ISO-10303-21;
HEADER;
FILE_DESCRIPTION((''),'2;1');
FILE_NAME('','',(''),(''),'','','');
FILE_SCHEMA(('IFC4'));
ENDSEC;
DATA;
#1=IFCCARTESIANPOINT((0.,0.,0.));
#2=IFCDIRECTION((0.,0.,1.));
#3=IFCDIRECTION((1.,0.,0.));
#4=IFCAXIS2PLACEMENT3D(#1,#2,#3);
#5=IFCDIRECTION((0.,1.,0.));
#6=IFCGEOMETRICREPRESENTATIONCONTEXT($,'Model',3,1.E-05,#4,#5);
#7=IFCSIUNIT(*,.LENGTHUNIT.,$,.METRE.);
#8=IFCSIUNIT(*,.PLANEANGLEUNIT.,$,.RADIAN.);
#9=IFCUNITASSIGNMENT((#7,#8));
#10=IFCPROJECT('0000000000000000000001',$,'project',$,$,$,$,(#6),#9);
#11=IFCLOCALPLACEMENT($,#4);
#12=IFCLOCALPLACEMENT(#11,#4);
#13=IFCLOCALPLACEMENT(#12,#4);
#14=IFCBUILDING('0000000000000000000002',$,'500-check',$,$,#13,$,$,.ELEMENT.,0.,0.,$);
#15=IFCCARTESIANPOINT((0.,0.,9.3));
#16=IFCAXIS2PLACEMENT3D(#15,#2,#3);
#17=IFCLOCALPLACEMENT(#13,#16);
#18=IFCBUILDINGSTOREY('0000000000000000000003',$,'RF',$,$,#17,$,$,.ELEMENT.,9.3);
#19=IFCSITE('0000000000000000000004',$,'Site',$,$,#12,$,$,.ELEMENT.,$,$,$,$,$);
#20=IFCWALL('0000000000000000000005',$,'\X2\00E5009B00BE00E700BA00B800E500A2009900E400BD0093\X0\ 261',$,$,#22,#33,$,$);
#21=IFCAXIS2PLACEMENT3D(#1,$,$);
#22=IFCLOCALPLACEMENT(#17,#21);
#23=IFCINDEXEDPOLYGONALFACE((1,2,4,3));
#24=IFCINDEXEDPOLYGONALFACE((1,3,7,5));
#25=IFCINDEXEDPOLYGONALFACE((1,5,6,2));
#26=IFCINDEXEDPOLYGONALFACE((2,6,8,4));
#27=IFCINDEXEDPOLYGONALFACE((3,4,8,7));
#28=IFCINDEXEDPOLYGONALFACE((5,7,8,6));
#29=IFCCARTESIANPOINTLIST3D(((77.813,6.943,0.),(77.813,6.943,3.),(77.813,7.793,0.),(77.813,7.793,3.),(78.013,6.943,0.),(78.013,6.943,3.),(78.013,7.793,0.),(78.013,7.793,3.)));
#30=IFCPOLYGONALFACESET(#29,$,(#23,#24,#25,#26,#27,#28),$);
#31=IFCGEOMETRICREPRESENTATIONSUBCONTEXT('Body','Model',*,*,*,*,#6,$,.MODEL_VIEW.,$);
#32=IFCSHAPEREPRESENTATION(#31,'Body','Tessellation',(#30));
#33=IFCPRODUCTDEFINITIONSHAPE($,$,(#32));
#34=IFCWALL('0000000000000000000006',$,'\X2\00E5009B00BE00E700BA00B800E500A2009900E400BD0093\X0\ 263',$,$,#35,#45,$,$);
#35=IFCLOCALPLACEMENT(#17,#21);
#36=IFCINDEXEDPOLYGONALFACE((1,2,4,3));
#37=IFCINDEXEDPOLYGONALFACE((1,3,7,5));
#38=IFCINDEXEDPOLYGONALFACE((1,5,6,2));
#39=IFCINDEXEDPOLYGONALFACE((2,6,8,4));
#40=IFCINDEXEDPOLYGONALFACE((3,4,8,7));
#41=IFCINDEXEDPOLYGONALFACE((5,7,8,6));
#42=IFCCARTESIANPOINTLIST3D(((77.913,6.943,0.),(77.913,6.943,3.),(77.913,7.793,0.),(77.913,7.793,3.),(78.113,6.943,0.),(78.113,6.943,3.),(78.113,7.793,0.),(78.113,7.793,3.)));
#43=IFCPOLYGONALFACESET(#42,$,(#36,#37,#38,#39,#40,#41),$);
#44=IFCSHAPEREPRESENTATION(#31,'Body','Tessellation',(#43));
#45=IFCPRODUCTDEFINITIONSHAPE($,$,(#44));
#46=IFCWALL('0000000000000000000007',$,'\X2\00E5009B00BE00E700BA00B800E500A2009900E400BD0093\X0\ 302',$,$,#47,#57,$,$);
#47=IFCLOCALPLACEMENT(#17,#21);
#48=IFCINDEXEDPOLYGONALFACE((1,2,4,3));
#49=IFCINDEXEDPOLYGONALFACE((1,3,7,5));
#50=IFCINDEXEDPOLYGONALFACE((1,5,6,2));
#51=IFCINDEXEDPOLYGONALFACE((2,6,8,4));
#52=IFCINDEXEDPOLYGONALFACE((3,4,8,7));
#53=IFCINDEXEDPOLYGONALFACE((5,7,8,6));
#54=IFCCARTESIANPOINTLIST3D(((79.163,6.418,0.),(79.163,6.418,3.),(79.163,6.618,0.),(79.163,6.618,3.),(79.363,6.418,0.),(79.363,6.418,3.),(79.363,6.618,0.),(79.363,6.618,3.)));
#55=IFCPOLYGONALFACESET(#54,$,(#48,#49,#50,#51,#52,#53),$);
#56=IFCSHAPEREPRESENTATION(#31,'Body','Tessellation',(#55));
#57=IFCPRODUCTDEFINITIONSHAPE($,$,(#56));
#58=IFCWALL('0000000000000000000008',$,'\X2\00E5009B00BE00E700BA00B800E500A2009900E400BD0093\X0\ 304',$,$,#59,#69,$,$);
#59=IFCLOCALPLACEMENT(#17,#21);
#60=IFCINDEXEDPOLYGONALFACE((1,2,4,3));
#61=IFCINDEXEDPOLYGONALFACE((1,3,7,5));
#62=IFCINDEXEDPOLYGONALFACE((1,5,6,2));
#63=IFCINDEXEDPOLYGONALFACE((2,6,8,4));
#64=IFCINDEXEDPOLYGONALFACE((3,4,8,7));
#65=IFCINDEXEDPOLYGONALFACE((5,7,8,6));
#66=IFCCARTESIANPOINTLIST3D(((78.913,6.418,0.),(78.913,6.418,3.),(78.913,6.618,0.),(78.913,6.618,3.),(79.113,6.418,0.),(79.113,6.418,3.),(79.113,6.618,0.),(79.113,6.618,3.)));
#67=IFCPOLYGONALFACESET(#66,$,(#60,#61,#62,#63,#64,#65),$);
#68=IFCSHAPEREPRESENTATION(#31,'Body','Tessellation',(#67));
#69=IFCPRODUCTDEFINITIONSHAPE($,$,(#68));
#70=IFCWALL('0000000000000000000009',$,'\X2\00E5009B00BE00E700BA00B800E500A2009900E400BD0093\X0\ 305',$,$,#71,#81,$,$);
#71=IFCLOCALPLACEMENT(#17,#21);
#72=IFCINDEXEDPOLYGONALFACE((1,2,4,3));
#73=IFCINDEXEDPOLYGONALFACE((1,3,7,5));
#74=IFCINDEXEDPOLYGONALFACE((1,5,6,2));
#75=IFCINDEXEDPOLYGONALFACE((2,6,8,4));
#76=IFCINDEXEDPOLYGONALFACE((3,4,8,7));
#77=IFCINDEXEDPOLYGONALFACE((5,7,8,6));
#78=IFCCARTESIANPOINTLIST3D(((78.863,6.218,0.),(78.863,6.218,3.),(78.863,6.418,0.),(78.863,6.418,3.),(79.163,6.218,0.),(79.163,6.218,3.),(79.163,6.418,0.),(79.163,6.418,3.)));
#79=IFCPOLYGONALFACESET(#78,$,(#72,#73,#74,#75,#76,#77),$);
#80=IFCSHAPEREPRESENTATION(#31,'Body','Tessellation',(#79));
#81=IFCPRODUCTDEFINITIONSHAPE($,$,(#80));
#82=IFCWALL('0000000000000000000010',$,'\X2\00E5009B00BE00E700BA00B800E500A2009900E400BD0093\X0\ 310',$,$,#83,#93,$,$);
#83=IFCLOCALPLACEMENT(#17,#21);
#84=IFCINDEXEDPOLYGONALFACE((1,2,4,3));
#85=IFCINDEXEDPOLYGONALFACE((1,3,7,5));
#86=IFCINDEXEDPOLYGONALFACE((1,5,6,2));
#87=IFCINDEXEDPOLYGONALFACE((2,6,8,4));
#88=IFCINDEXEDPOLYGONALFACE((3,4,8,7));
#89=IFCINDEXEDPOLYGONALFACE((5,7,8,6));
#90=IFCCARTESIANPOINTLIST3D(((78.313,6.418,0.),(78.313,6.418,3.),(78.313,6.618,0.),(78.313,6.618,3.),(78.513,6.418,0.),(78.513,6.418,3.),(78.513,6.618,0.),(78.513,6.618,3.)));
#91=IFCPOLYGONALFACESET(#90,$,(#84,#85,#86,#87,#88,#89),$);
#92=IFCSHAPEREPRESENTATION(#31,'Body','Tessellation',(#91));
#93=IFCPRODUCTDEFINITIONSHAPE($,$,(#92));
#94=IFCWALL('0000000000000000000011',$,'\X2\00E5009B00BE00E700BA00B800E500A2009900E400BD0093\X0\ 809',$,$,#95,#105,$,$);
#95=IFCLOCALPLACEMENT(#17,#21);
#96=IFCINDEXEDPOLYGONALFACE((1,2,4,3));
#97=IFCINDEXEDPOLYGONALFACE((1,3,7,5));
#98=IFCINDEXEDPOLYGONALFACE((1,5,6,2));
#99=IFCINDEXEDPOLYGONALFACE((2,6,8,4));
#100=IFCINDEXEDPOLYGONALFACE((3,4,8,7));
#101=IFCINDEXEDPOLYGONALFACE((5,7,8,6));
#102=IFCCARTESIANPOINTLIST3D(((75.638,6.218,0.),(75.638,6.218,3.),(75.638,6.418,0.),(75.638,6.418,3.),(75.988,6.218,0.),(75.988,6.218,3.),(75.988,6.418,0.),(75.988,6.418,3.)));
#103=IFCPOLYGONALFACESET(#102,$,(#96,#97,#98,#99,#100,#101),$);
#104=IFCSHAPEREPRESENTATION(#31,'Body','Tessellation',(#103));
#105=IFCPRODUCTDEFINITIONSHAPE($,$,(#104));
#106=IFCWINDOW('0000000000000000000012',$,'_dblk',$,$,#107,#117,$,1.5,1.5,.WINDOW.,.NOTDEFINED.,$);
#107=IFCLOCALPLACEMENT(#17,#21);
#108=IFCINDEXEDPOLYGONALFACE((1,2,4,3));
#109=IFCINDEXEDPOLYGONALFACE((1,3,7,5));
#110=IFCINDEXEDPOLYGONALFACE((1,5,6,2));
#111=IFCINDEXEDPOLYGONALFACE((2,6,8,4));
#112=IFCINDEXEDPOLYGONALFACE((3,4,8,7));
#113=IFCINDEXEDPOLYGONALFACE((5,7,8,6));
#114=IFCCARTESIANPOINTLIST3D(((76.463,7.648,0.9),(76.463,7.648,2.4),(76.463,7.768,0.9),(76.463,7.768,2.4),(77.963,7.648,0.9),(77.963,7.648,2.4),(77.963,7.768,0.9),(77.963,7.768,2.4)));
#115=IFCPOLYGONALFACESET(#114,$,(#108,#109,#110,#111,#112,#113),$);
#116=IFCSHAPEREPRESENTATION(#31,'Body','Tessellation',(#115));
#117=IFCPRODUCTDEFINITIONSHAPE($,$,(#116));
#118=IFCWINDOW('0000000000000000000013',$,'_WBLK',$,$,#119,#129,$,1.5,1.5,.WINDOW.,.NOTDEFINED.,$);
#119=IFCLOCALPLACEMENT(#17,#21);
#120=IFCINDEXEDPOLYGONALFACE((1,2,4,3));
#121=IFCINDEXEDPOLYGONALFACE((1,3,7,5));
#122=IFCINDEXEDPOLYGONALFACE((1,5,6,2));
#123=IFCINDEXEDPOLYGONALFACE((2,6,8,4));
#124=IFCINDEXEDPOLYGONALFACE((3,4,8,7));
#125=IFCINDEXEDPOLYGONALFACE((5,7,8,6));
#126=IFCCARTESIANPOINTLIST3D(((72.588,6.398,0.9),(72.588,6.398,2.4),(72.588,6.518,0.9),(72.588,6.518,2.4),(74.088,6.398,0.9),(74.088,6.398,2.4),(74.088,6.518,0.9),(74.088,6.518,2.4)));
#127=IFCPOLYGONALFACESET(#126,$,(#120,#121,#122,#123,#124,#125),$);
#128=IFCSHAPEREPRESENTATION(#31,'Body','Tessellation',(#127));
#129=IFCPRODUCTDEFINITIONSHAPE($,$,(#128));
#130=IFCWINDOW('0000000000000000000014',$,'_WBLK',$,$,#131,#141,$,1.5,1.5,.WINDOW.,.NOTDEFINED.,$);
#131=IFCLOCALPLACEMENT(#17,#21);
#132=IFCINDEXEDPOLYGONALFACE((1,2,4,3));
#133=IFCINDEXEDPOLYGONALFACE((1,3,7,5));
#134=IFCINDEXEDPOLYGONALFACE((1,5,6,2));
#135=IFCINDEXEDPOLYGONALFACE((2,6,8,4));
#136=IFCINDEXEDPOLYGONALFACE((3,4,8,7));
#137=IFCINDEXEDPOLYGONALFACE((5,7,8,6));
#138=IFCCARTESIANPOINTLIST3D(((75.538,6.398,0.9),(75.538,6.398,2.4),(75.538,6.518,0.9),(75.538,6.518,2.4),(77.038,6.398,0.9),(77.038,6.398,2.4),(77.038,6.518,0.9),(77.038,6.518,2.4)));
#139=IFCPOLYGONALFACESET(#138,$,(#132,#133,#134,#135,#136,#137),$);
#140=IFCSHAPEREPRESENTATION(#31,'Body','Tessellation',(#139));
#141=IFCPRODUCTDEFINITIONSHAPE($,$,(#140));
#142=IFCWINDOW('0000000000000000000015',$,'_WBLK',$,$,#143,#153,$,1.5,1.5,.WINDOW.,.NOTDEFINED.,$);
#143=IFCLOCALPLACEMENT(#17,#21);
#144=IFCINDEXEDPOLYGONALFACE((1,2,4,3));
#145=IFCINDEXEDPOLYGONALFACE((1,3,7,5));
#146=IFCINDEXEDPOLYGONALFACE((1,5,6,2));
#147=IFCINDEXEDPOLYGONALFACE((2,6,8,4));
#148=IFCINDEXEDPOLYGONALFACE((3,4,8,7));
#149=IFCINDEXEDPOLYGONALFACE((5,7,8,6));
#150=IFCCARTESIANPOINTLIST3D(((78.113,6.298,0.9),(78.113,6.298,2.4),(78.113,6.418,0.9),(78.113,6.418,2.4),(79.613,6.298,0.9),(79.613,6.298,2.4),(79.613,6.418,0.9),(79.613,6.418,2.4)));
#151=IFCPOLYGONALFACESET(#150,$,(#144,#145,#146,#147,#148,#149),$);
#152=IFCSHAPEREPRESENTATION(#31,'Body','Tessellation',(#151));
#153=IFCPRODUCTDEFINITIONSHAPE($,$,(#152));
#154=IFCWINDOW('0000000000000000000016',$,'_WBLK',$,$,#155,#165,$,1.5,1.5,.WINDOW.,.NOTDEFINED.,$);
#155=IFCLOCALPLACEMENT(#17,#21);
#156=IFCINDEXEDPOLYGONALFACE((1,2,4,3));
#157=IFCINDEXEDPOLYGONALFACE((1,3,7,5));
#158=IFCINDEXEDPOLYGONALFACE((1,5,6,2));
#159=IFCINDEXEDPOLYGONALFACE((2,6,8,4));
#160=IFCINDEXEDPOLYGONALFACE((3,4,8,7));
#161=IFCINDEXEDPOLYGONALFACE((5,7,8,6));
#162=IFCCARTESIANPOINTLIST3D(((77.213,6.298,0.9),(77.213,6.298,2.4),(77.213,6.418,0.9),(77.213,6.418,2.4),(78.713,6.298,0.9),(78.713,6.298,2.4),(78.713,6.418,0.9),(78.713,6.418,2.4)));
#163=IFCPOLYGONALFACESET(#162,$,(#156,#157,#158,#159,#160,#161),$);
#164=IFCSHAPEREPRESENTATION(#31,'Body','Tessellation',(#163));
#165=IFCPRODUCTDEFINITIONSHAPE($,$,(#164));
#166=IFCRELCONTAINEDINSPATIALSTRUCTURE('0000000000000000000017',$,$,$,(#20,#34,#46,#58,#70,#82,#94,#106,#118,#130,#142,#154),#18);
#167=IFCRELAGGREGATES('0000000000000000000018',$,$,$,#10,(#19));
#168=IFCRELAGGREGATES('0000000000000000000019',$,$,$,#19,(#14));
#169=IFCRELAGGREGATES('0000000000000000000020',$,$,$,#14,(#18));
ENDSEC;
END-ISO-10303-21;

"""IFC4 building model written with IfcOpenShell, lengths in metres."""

from ifc_helpers import new_model, si_unit, direction, frame, frame_2d, origin_with_axes, place, context, subcontext, project, spatial, rectangle, extrude, element, save


model = new_model("IFC4")

# Units and contexts
model_context = context("Model", 3, precision=1e-05, world=origin_with_axes(), true_north=direction((0.0, 1.0, 0.0)))
body_context = subcontext(model_context, "Body", "Model", "MODEL_VIEW")
ifc_project = project(units=[si_unit("LENGTHUNIT", "METRE"), si_unit("PLANEANGLEUNIT", "RADIAN")], contexts=[model_context])

# Site, building, storey
placement = place(None, origin_with_axes())
site_placement = place(placement, origin_with_axes())
site = spatial("IfcSite", under=ifc_project, at=site_placement, Name="Site", CompositionType="ELEMENT")
building_placement = place(site_placement, origin_with_axes())
building = spatial("IfcBuilding", under=site, at=building_placement, Name="500-check", CompositionType="ELEMENT", ElevationOfRefHeight=0.0, ElevationOfTerrain=0.0)
storey_placement = place(building_placement, frame((0.0, 0.0, 9.3), z_axis=(0.0, 0.0, 1.0), x_axis=(1.0, 0.0, 0.0)))
storey = spatial("IfcBuildingStorey", under=building, at=storey_placement, Name="RF", CompositionType="ELEMENT", Elevation=9.3)

# Walls
for number, where, z_axis, x_axis, name in (
    (1, (77.913, 7.368, 0.0), (0.0, 0.0, 1.0), (0.0, -1.0, 0.0), "å\u009b¾çº¸å¢\u0099ä½\u0093 261"),
    (2, (78.013, 7.368, 0.0), (0.0, 0.0, 1.0), (0.0, -1.0, 0.0), "å\u009b¾çº¸å¢\u0099ä½\u0093 263"),
):
    element("IfcWall", number, at=place(storey_placement, frame(where, z_axis=z_axis, x_axis=x_axis)), inside=storey, Name=name, context=body_context, shape_type="SweptSolid", body=[
        extrude(rectangle(XDim=0.85, YDim=0.2, at=frame_2d((0.0, 0.0), x_axis=(1.0, 0.0, 0.0))), frame((0.0, 0.0, 0.0), z_axis=(0.0, 0.0, 1.0)), (0.0, 0.0, 1.0), 3.0),
    ])
for number, where, z_axis, x_axis, name in (
    (3, (79.263, 6.518, 0.0), (0.0, 0.0, 1.0), (1.0, 0.0, 0.0), "å\u009b¾çº¸å¢\u0099ä½\u0093 302"),
    (4, (79.013, 6.518, 0.0), (0.0, 0.0, 1.0), (1.0, 0.0, 0.0), "å\u009b¾çº¸å¢\u0099ä½\u0093 304"),
):
    element("IfcWall", number, at=place(storey_placement, frame(where, z_axis=z_axis, x_axis=x_axis)), inside=storey, Name=name, context=body_context, shape_type="SweptSolid", body=[
        extrude(rectangle(XDim=0.2, YDim=0.2, at=frame_2d((0.0, 0.0), x_axis=(1.0, 0.0, 0.0))), frame((0.0, 0.0, 0.0), z_axis=(0.0, 0.0, 1.0)), (0.0, 0.0, 1.0), 3.0),
    ])
wall_1_placement = place(storey_placement, frame((79.013, 6.318, 0.0), z_axis=(0.0, 0.0, 1.0), x_axis=(1.0, 0.0, 0.0)))
element("IfcWall", 5, at=wall_1_placement, inside=storey, Name="å\u009b¾çº¸å¢\u0099ä½\u0093 305", context=body_context, shape_type="SweptSolid", body=[
    extrude(rectangle(XDim=0.3, YDim=0.2, at=frame_2d((0.0, 0.0), x_axis=(1.0, 0.0, 0.0))), frame((0.0, 0.0, 0.0), z_axis=(0.0, 0.0, 1.0)), (0.0, 0.0, 1.0), 3.0),
])
for number, where, z_axis, x_axis, name in (
    (6, (78.413, 6.518, 0.0), (0.0, 0.0, 1.0), (0.0, -1.0, 0.0), "å\u009b¾çº¸å¢\u0099ä½\u0093 310"),
):
    element("IfcWall", number, at=place(storey_placement, frame(where, z_axis=z_axis, x_axis=x_axis)), inside=storey, Name=name, context=body_context, shape_type="SweptSolid", body=[
        extrude(rectangle(XDim=0.2, YDim=0.2, at=frame_2d((0.0, 0.0), x_axis=(1.0, 0.0, 0.0))), frame((0.0, 0.0, 0.0), z_axis=(0.0, 0.0, 1.0)), (0.0, 0.0, 1.0), 3.0),
    ])
wall_2_placement = place(storey_placement, frame((75.813, 6.318, 0.0), z_axis=(0.0, 0.0, 1.0), x_axis=(1.0, 0.0, 0.0)))
element("IfcWall", 7, at=wall_2_placement, inside=storey, Name="å\u009b¾çº¸å¢\u0099ä½\u0093 809", context=body_context, shape_type="SweptSolid", body=[
    extrude(rectangle(XDim=0.35, YDim=0.2, at=frame_2d((0.0, 0.0), x_axis=(1.0, 0.0, 0.0))), frame((0.0, 0.0, 0.0), z_axis=(0.0, 0.0, 1.0)), (0.0, 0.0, 1.0), 3.0),
])

# Windows
for number, where, z_axis, x_axis, name in (
    (8, (77.213, 7.708, 0.9), (0.0, 0.0, 1.0), (1.0, 0.0, 0.0), "_dblk"),
    (9, (73.338, 6.458, 0.9), (0.0, 0.0, 1.0), (1.0, 0.0, 0.0), "_WBLK"),
    (10, (76.288, 6.458, 0.9), (0.0, 0.0, 1.0), (1.0, 0.0, 0.0), "_WBLK"),
    (11, (78.863, 6.358, 0.9), (0.0, 0.0, 1.0), (1.0, 0.0, 0.0), "_WBLK"),
    (12, (77.963, 6.358, 0.9), (0.0, 0.0, 1.0), (1.0, 0.0, 0.0), "_WBLK"),
):
    element("IfcWindow", number, at=place(storey_placement, frame(where, z_axis=z_axis, x_axis=x_axis)), inside=storey, Name=name, OverallHeight=1.5, OverallWidth=1.5, PartitioningType="NOTDEFINED", PredefinedType="WINDOW", context=body_context, shape_type="SweptSolid", body=[
        extrude(rectangle(XDim=1.5, YDim=0.12, at=frame_2d((0.0, 0.0), x_axis=(1.0, 0.0, 0.0))), frame((0.0, 0.0, 0.0), z_axis=(0.0, 0.0, 1.0)), (0.0, 0.0, 1.0), 1.5),
    ])

save(model, "model.ifc")
